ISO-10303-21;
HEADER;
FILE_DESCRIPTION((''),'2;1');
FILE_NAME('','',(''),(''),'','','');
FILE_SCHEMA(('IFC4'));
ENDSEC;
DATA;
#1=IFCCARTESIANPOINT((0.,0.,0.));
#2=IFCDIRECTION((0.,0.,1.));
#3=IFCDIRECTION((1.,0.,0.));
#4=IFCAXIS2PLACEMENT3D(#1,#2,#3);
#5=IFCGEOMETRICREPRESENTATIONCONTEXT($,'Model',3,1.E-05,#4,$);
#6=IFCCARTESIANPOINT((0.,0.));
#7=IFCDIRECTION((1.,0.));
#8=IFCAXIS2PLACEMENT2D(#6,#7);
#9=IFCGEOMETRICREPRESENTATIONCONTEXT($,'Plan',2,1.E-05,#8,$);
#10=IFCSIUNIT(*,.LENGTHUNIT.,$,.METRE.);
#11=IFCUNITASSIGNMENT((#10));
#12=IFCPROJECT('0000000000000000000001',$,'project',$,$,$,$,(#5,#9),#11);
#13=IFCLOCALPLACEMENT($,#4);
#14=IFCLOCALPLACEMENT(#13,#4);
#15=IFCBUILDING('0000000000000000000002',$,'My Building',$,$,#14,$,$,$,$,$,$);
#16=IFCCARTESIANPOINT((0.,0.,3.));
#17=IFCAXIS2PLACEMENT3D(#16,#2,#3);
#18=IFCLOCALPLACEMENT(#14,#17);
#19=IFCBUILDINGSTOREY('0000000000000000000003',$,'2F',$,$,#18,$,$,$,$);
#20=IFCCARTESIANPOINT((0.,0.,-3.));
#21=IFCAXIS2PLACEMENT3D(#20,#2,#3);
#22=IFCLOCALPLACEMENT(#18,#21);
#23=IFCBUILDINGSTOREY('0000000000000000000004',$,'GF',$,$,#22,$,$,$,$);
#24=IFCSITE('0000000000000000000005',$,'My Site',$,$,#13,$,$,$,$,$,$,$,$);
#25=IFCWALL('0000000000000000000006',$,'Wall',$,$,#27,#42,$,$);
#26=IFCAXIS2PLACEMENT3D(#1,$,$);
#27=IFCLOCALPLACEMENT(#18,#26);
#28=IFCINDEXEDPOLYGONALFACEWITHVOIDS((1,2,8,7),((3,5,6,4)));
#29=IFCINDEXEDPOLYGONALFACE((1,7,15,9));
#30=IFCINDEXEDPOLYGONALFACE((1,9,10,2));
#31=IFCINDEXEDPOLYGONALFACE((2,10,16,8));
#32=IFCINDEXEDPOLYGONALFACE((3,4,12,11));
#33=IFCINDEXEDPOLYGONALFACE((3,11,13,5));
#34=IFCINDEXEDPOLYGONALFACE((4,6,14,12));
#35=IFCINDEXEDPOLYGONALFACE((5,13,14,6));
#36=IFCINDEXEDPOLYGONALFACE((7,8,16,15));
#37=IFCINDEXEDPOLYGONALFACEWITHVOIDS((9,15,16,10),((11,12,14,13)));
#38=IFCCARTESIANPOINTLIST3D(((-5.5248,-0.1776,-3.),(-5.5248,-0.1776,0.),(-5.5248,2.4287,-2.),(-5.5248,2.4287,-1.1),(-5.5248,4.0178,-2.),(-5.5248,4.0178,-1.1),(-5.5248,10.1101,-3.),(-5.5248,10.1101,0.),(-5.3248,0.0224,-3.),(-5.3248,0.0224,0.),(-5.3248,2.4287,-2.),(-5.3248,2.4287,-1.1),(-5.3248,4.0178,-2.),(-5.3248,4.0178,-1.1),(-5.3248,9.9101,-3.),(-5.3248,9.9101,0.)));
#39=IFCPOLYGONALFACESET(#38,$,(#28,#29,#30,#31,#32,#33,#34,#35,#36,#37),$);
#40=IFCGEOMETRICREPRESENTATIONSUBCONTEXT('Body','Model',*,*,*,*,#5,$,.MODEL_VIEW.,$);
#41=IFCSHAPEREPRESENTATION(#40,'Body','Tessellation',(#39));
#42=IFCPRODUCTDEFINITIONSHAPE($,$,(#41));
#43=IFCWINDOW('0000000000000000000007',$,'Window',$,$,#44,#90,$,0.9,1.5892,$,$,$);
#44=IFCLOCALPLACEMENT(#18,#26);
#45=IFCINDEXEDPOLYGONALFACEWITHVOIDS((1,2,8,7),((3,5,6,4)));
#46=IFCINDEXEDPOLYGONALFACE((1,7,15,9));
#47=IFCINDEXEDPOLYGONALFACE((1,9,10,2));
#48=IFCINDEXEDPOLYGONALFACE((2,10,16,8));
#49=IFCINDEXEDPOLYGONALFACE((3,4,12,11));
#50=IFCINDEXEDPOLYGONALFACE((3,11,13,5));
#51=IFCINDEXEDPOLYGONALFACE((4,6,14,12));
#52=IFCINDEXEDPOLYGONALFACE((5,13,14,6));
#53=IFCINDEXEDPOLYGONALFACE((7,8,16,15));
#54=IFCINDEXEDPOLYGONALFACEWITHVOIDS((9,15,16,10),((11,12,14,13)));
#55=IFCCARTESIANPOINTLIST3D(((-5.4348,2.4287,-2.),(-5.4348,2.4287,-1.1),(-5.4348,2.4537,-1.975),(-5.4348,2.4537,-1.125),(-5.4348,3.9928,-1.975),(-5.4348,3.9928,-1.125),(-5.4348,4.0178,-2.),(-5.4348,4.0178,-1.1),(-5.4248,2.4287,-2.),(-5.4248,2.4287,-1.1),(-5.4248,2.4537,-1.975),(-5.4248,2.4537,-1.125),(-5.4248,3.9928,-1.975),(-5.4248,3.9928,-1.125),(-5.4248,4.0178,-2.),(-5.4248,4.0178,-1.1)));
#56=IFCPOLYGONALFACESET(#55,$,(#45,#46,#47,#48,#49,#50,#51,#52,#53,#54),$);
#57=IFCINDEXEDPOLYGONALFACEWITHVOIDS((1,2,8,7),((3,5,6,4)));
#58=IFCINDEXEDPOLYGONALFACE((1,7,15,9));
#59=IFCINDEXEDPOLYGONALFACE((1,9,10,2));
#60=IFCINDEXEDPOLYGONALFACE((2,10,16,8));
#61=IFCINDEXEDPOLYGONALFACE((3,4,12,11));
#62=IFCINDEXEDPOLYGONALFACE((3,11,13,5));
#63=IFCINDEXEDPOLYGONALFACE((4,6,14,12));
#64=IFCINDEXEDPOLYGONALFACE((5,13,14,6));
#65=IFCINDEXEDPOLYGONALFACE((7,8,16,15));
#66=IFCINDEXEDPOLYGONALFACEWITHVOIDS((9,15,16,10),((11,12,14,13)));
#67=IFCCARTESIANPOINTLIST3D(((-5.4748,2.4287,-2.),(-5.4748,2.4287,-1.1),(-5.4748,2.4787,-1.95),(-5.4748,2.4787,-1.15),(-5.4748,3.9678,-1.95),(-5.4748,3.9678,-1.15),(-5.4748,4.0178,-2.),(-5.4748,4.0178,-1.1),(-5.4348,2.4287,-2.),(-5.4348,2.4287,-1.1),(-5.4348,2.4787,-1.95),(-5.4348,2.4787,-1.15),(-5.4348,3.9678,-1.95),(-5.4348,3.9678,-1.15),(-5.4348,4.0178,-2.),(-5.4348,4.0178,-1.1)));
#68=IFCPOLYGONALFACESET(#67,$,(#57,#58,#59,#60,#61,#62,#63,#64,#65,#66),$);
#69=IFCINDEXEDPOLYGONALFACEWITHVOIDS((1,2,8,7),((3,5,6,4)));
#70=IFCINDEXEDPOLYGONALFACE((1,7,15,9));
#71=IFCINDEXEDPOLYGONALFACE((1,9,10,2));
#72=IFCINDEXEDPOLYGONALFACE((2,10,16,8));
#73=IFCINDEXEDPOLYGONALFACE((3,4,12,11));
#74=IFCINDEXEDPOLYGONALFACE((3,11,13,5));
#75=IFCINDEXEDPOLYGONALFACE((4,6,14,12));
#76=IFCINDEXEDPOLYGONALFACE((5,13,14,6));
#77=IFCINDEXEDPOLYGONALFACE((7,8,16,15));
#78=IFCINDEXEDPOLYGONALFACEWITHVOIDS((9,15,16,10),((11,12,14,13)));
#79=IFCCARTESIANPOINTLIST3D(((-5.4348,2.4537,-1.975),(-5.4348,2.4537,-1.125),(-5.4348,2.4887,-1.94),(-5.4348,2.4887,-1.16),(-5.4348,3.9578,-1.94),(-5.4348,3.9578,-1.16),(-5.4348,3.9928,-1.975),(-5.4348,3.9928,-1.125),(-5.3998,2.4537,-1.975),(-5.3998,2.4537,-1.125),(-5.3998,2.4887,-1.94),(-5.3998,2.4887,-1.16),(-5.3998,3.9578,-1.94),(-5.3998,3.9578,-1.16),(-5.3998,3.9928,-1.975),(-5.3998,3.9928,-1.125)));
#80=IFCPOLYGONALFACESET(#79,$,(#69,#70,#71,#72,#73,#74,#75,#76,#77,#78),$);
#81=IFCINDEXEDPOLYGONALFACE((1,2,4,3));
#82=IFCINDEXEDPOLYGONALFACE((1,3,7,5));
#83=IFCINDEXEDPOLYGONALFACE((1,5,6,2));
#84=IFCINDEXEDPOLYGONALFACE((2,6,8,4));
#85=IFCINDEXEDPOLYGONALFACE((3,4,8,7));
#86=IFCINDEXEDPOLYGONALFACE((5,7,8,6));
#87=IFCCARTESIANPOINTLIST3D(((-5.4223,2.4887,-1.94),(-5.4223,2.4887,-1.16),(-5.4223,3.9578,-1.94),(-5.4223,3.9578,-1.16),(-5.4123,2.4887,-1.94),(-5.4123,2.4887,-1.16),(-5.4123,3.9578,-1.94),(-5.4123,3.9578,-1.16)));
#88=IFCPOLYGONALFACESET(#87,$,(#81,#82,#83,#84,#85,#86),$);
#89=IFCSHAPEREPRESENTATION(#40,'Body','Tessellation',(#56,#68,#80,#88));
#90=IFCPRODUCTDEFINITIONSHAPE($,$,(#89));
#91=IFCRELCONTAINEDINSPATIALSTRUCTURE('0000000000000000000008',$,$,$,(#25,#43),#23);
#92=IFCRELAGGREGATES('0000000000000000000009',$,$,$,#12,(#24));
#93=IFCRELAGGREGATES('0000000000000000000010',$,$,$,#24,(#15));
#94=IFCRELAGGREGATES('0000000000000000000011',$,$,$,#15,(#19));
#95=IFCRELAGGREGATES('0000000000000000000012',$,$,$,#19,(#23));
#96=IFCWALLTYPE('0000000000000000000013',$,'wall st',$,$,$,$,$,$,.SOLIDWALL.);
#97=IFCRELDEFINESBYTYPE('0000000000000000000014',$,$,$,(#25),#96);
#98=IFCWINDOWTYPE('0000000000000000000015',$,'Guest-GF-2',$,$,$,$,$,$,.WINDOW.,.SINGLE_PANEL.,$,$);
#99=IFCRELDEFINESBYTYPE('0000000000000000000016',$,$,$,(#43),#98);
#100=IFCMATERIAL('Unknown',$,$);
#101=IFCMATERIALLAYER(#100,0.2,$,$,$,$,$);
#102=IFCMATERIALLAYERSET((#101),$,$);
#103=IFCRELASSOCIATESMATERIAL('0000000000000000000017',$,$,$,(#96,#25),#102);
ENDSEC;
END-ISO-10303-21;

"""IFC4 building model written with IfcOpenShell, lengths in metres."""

from ifc_helpers import new_model, entity, si_unit, frame, origin_with_axes, origin_2d_with_axis, place, context, subcontext, project, spatial, line, indexed_curve, outline, extrude, shape, source, transform, mapped, material, layer, layer_set, layer_usage, type_object, type_shapes, element, fill, save


model = new_model("IFC4")

# Units and contexts
model_context = context("Model", 3, precision=1e-05, world=origin_with_axes())
plan_context = context("Plan", 2, precision=1e-05, world=origin_2d_with_axis())
body_context_1 = subcontext(model_context, "Body", "Model", "MODEL_VIEW")
body_context_2 = subcontext(plan_context, "Body", "Plan", "PLAN_VIEW")
ifc_project = project(units=[si_unit("LENGTHUNIT", "METRE")], contexts=[model_context, plan_context])

# Site, building, storeys
site_placement = place(None, origin_with_axes())
site = spatial("IfcSite", under=ifc_project, at=site_placement, Name="My Site")
building_placement = place(site_placement, origin_with_axes())
building = spatial("IfcBuilding", under=site, at=building_placement, Name="My Building")
storey_1_placement = place(building_placement, frame((0.0, 0.0, 3.0), z_axis=(0.0, 0.0, 1.0), x_axis=(1.0, 0.0, 0.0)))
storey_1 = spatial("IfcBuildingStorey", under=building, at=storey_1_placement, Name="2F")
storey_2_placement = place(storey_1_placement, frame((0.0, 0.0, -3.0), z_axis=(0.0, 0.0, 1.0), x_axis=(1.0, 0.0, 0.0)))
storey_2 = spatial("IfcBuildingStorey", under=storey_1, at=storey_2_placement, Name="GF")

# Shared definitions
ifc_material = material(Name="Unknown")

# Shared definitions
ifc_layer = layer(ifc_material, 0.2)
ifc_layer_set = layer_set([ifc_layer])
wall_type = type_object("IfcWallType", Name="wall st", PredefinedType="SOLIDWALL", material=ifc_layer_set)

# Wall, opening, window
ifc_layer_usage_1 = layer_usage(ifc_layer_set, "AXIS2", "POSITIVE", 0.0)
wall_1_placement = place(storey_2_placement, frame((-5.5248, 10.1101, 0.0), z_axis=(0.0, 0.0, 1.0), x_axis=(0.0, -1.0, 0.0)))
wall_1 = element("IfcWall", 1, at=wall_1_placement, inside=storey_2, type_object=wall_type, material=ifc_layer_usage_1, Name="Wall", context=body_context_1, shape_type="SweptSolid", body=[
    extrude(outline(indexed_curve([(0.0, 0.0), (0.2, 0.2), (10.0877, 0.2), (10.2877, 0.0)], segments=[line(1, 2, 3, 4, 1)])), origin_with_axes(), (0.0, 0.0, 1.0), 3.0),
])
shared_shape_1 = source(origin_with_axes(), body_context_1, "Body", "SweptSolid", [
    extrude(outline(indexed_curve([(0.0, 0.0), (1.5892, 0.0), (1.5892, 0.9), (0.0, 0.9)], segments=[line(1, 2, 3, 4, 1)])), frame((0.0, -0.6, 0.0), z_axis=(0.0, -1.0, 0.0), x_axis=(1.0, 0.0, 0.0)), (0.0, 0.0, -1.0), 1.2),
])
opening_1_placement = place(wall_1_placement, frame((6.0922, 0.0, 1.0), z_axis=(0.0, 0.0, 1.0), x_axis=(1.0, 0.0, 0.0)))
opening_1 = element("IfcOpeningElement", 2, at=opening_1_placement, cuts=wall_1, PredefinedType="OPENING", context=body_context_1, shape_type="MappedRepresentation", body=[
    mapped(shared_shape_1, transform((0.0, 0.0, 0.0), x_axis=(1.0, 0.0, 0.0), y_axis=(0.0, 1.0, 0.0), z_axis=(0.0, 0.0, 1.0), scale=1.0)),
])
window_type_1 = type_object("IfcWindowType", Name="Guest-GF-2", PartitioningType="SINGLE_PANEL", PredefinedType="WINDOW")
shared_shape_2 = source(origin_with_axes(), body_context_1, "Body", "SweptSolid", [
    extrude(outline(indexed_curve([(0.0, 0.0), (1.5892, 0.0), (1.5892, 0.9), (0.0, 0.9)], segments=[line(1, 2, 3, 4, 1)]), holes=[indexed_curve([(0.025, 0.025), (1.5642, 0.025), (1.5642, 0.875), (0.025, 0.875)], segments=[line(1, 2, 3, 4, 1)])]), frame((0.0, 0.09, 0.0), z_axis=(0.0, -1.0, 0.0), x_axis=(1.0, 0.0, 0.0)), (0.0, 0.0, -1.0), 0.01),
    extrude(outline(indexed_curve([(0.0, 0.0), (1.5892, 0.0), (1.5892, 0.9), (0.0, 0.9)], segments=[line(1, 2, 3, 4, 1)]), holes=[indexed_curve([(0.05, 0.05), (1.5392, 0.05), (1.5392, 0.85), (0.05, 0.85)], segments=[line(1, 2, 3, 4, 1)])]), frame((0.0, 0.05, 0.0), z_axis=(0.0, -1.0, 0.0), x_axis=(1.0, 0.0, 0.0)), (0.0, 0.0, -1.0), 0.04),
    extrude(outline(indexed_curve([(0.0, 0.0), (1.5392, 0.0), (1.5392, 0.85), (0.0, 0.85)], segments=[line(1, 2, 3, 4, 1)]), holes=[indexed_curve([(0.035, 0.035), (1.5042, 0.035), (1.5042, 0.815), (0.035, 0.815)], segments=[line(1, 2, 3, 4, 1)])]), frame((0.025, 0.09, 0.025), z_axis=(0.0, -1.0, 0.0), x_axis=(1.0, 0.0, 0.0)), (0.0, 0.0, -1.0), 0.035),
    extrude(outline(indexed_curve([(0.035, 0.035), (1.5042, 0.035), (1.5042, 0.815), (0.035, 0.815)], segments=[line(1, 2, 3, 4, 1)])), frame((0.025, 0.1025, 0.025), z_axis=(0.0, -1.0, 0.0), x_axis=(1.0, 0.0, 0.0)), (0.0, 0.0, -1.0), 0.01),
])
shared_shape_3 = source(origin_with_axes(), body_context_2, "Body", "Curve2D", [
    entity("IfcIndexedPolyCurve", entity("IfcCartesianPointList2D", [[0.05, 0.05], [1.5392, 0.05]])),
    entity("IfcIndexedPolyCurve", entity("IfcCartesianPointList2D", [[0.0, 0.1], [0.025, 0.1], [0.025, 0.09], [0.05, 0.09], [0.05, 0.05], [0.0, 0.05]]), [entity("IfcLineIndex", [1, 2, 3, 4, 5, 6, 1])]),
    entity("IfcIndexedPolyCurve", entity("IfcCartesianPointList2D", [[1.5892, 0.1], [1.5642, 0.1], [1.5642, 0.09], [1.5392, 0.09], [1.5392, 0.05], [1.5892, 0.05]]), [entity("IfcLineIndex", [1, 2, 3, 4, 5, 6, 1])]),
    entity("IfcIndexedPolyCurve", entity("IfcCartesianPointList2D", [[0.025, 0.09], [0.06, 0.09], [0.06, 0.125], [0.025, 0.125]]), [entity("IfcLineIndex", [1, 2, 3, 4, 1])]),
    entity("IfcIndexedPolyCurve", entity("IfcCartesianPointList2D", [[1.5642, 0.09], [1.5292, 0.09], [1.5292, 0.125], [1.5642, 0.125]]), [entity("IfcLineIndex", [1, 2, 3, 4, 1])]),
    entity("IfcIndexedPolyCurve", entity("IfcCartesianPointList2D", [[0.06, 0.09], [1.5292, 0.09]])),
    entity("IfcIndexedPolyCurve", entity("IfcCartesianPointList2D", [[0.06, 0.125], [1.5292, 0.125]])),
    entity("IfcIndexedPolyCurve", entity("IfcCartesianPointList2D", [[0.06, 0.1075], [1.5292, 0.1075]])),
])
type_shapes(window_type_1, [shared_shape_2, shared_shape_3])
window_1_placement = place(opening_1_placement, frame((0.0, 0.0, 0.0), z_axis=(0.0, 0.0, 1.0), x_axis=(1.0, 0.0, 0.0)))
window_1 = element("IfcWindow", 3, at=window_1_placement, inside=storey_2, type_object=window_type_1, Name="Window", OverallHeight=0.9, OverallWidth=1.5892, shapes=[
    shape(body_context_1, "Body", "MappedRepresentation", [mapped(shared_shape_2, transform((0.0, 0.0, 0.0), x_axis=(1.0, 0.0, 0.0), y_axis=(0.0, 1.0, 0.0), z_axis=(0.0, 0.0, 1.0), scale=1.0))]),
    shape(body_context_2, "Body", "MappedRepresentation", [mapped(shared_shape_3, transform((0.0, 0.0, 0.0), x_axis=(1.0, 0.0, 0.0), y_axis=(0.0, 1.0, 0.0), z_axis=(0.0, 0.0, 1.0), scale=1.0))]),
])
fill(opening_1, window_1)

save(model, "model.ifc")
